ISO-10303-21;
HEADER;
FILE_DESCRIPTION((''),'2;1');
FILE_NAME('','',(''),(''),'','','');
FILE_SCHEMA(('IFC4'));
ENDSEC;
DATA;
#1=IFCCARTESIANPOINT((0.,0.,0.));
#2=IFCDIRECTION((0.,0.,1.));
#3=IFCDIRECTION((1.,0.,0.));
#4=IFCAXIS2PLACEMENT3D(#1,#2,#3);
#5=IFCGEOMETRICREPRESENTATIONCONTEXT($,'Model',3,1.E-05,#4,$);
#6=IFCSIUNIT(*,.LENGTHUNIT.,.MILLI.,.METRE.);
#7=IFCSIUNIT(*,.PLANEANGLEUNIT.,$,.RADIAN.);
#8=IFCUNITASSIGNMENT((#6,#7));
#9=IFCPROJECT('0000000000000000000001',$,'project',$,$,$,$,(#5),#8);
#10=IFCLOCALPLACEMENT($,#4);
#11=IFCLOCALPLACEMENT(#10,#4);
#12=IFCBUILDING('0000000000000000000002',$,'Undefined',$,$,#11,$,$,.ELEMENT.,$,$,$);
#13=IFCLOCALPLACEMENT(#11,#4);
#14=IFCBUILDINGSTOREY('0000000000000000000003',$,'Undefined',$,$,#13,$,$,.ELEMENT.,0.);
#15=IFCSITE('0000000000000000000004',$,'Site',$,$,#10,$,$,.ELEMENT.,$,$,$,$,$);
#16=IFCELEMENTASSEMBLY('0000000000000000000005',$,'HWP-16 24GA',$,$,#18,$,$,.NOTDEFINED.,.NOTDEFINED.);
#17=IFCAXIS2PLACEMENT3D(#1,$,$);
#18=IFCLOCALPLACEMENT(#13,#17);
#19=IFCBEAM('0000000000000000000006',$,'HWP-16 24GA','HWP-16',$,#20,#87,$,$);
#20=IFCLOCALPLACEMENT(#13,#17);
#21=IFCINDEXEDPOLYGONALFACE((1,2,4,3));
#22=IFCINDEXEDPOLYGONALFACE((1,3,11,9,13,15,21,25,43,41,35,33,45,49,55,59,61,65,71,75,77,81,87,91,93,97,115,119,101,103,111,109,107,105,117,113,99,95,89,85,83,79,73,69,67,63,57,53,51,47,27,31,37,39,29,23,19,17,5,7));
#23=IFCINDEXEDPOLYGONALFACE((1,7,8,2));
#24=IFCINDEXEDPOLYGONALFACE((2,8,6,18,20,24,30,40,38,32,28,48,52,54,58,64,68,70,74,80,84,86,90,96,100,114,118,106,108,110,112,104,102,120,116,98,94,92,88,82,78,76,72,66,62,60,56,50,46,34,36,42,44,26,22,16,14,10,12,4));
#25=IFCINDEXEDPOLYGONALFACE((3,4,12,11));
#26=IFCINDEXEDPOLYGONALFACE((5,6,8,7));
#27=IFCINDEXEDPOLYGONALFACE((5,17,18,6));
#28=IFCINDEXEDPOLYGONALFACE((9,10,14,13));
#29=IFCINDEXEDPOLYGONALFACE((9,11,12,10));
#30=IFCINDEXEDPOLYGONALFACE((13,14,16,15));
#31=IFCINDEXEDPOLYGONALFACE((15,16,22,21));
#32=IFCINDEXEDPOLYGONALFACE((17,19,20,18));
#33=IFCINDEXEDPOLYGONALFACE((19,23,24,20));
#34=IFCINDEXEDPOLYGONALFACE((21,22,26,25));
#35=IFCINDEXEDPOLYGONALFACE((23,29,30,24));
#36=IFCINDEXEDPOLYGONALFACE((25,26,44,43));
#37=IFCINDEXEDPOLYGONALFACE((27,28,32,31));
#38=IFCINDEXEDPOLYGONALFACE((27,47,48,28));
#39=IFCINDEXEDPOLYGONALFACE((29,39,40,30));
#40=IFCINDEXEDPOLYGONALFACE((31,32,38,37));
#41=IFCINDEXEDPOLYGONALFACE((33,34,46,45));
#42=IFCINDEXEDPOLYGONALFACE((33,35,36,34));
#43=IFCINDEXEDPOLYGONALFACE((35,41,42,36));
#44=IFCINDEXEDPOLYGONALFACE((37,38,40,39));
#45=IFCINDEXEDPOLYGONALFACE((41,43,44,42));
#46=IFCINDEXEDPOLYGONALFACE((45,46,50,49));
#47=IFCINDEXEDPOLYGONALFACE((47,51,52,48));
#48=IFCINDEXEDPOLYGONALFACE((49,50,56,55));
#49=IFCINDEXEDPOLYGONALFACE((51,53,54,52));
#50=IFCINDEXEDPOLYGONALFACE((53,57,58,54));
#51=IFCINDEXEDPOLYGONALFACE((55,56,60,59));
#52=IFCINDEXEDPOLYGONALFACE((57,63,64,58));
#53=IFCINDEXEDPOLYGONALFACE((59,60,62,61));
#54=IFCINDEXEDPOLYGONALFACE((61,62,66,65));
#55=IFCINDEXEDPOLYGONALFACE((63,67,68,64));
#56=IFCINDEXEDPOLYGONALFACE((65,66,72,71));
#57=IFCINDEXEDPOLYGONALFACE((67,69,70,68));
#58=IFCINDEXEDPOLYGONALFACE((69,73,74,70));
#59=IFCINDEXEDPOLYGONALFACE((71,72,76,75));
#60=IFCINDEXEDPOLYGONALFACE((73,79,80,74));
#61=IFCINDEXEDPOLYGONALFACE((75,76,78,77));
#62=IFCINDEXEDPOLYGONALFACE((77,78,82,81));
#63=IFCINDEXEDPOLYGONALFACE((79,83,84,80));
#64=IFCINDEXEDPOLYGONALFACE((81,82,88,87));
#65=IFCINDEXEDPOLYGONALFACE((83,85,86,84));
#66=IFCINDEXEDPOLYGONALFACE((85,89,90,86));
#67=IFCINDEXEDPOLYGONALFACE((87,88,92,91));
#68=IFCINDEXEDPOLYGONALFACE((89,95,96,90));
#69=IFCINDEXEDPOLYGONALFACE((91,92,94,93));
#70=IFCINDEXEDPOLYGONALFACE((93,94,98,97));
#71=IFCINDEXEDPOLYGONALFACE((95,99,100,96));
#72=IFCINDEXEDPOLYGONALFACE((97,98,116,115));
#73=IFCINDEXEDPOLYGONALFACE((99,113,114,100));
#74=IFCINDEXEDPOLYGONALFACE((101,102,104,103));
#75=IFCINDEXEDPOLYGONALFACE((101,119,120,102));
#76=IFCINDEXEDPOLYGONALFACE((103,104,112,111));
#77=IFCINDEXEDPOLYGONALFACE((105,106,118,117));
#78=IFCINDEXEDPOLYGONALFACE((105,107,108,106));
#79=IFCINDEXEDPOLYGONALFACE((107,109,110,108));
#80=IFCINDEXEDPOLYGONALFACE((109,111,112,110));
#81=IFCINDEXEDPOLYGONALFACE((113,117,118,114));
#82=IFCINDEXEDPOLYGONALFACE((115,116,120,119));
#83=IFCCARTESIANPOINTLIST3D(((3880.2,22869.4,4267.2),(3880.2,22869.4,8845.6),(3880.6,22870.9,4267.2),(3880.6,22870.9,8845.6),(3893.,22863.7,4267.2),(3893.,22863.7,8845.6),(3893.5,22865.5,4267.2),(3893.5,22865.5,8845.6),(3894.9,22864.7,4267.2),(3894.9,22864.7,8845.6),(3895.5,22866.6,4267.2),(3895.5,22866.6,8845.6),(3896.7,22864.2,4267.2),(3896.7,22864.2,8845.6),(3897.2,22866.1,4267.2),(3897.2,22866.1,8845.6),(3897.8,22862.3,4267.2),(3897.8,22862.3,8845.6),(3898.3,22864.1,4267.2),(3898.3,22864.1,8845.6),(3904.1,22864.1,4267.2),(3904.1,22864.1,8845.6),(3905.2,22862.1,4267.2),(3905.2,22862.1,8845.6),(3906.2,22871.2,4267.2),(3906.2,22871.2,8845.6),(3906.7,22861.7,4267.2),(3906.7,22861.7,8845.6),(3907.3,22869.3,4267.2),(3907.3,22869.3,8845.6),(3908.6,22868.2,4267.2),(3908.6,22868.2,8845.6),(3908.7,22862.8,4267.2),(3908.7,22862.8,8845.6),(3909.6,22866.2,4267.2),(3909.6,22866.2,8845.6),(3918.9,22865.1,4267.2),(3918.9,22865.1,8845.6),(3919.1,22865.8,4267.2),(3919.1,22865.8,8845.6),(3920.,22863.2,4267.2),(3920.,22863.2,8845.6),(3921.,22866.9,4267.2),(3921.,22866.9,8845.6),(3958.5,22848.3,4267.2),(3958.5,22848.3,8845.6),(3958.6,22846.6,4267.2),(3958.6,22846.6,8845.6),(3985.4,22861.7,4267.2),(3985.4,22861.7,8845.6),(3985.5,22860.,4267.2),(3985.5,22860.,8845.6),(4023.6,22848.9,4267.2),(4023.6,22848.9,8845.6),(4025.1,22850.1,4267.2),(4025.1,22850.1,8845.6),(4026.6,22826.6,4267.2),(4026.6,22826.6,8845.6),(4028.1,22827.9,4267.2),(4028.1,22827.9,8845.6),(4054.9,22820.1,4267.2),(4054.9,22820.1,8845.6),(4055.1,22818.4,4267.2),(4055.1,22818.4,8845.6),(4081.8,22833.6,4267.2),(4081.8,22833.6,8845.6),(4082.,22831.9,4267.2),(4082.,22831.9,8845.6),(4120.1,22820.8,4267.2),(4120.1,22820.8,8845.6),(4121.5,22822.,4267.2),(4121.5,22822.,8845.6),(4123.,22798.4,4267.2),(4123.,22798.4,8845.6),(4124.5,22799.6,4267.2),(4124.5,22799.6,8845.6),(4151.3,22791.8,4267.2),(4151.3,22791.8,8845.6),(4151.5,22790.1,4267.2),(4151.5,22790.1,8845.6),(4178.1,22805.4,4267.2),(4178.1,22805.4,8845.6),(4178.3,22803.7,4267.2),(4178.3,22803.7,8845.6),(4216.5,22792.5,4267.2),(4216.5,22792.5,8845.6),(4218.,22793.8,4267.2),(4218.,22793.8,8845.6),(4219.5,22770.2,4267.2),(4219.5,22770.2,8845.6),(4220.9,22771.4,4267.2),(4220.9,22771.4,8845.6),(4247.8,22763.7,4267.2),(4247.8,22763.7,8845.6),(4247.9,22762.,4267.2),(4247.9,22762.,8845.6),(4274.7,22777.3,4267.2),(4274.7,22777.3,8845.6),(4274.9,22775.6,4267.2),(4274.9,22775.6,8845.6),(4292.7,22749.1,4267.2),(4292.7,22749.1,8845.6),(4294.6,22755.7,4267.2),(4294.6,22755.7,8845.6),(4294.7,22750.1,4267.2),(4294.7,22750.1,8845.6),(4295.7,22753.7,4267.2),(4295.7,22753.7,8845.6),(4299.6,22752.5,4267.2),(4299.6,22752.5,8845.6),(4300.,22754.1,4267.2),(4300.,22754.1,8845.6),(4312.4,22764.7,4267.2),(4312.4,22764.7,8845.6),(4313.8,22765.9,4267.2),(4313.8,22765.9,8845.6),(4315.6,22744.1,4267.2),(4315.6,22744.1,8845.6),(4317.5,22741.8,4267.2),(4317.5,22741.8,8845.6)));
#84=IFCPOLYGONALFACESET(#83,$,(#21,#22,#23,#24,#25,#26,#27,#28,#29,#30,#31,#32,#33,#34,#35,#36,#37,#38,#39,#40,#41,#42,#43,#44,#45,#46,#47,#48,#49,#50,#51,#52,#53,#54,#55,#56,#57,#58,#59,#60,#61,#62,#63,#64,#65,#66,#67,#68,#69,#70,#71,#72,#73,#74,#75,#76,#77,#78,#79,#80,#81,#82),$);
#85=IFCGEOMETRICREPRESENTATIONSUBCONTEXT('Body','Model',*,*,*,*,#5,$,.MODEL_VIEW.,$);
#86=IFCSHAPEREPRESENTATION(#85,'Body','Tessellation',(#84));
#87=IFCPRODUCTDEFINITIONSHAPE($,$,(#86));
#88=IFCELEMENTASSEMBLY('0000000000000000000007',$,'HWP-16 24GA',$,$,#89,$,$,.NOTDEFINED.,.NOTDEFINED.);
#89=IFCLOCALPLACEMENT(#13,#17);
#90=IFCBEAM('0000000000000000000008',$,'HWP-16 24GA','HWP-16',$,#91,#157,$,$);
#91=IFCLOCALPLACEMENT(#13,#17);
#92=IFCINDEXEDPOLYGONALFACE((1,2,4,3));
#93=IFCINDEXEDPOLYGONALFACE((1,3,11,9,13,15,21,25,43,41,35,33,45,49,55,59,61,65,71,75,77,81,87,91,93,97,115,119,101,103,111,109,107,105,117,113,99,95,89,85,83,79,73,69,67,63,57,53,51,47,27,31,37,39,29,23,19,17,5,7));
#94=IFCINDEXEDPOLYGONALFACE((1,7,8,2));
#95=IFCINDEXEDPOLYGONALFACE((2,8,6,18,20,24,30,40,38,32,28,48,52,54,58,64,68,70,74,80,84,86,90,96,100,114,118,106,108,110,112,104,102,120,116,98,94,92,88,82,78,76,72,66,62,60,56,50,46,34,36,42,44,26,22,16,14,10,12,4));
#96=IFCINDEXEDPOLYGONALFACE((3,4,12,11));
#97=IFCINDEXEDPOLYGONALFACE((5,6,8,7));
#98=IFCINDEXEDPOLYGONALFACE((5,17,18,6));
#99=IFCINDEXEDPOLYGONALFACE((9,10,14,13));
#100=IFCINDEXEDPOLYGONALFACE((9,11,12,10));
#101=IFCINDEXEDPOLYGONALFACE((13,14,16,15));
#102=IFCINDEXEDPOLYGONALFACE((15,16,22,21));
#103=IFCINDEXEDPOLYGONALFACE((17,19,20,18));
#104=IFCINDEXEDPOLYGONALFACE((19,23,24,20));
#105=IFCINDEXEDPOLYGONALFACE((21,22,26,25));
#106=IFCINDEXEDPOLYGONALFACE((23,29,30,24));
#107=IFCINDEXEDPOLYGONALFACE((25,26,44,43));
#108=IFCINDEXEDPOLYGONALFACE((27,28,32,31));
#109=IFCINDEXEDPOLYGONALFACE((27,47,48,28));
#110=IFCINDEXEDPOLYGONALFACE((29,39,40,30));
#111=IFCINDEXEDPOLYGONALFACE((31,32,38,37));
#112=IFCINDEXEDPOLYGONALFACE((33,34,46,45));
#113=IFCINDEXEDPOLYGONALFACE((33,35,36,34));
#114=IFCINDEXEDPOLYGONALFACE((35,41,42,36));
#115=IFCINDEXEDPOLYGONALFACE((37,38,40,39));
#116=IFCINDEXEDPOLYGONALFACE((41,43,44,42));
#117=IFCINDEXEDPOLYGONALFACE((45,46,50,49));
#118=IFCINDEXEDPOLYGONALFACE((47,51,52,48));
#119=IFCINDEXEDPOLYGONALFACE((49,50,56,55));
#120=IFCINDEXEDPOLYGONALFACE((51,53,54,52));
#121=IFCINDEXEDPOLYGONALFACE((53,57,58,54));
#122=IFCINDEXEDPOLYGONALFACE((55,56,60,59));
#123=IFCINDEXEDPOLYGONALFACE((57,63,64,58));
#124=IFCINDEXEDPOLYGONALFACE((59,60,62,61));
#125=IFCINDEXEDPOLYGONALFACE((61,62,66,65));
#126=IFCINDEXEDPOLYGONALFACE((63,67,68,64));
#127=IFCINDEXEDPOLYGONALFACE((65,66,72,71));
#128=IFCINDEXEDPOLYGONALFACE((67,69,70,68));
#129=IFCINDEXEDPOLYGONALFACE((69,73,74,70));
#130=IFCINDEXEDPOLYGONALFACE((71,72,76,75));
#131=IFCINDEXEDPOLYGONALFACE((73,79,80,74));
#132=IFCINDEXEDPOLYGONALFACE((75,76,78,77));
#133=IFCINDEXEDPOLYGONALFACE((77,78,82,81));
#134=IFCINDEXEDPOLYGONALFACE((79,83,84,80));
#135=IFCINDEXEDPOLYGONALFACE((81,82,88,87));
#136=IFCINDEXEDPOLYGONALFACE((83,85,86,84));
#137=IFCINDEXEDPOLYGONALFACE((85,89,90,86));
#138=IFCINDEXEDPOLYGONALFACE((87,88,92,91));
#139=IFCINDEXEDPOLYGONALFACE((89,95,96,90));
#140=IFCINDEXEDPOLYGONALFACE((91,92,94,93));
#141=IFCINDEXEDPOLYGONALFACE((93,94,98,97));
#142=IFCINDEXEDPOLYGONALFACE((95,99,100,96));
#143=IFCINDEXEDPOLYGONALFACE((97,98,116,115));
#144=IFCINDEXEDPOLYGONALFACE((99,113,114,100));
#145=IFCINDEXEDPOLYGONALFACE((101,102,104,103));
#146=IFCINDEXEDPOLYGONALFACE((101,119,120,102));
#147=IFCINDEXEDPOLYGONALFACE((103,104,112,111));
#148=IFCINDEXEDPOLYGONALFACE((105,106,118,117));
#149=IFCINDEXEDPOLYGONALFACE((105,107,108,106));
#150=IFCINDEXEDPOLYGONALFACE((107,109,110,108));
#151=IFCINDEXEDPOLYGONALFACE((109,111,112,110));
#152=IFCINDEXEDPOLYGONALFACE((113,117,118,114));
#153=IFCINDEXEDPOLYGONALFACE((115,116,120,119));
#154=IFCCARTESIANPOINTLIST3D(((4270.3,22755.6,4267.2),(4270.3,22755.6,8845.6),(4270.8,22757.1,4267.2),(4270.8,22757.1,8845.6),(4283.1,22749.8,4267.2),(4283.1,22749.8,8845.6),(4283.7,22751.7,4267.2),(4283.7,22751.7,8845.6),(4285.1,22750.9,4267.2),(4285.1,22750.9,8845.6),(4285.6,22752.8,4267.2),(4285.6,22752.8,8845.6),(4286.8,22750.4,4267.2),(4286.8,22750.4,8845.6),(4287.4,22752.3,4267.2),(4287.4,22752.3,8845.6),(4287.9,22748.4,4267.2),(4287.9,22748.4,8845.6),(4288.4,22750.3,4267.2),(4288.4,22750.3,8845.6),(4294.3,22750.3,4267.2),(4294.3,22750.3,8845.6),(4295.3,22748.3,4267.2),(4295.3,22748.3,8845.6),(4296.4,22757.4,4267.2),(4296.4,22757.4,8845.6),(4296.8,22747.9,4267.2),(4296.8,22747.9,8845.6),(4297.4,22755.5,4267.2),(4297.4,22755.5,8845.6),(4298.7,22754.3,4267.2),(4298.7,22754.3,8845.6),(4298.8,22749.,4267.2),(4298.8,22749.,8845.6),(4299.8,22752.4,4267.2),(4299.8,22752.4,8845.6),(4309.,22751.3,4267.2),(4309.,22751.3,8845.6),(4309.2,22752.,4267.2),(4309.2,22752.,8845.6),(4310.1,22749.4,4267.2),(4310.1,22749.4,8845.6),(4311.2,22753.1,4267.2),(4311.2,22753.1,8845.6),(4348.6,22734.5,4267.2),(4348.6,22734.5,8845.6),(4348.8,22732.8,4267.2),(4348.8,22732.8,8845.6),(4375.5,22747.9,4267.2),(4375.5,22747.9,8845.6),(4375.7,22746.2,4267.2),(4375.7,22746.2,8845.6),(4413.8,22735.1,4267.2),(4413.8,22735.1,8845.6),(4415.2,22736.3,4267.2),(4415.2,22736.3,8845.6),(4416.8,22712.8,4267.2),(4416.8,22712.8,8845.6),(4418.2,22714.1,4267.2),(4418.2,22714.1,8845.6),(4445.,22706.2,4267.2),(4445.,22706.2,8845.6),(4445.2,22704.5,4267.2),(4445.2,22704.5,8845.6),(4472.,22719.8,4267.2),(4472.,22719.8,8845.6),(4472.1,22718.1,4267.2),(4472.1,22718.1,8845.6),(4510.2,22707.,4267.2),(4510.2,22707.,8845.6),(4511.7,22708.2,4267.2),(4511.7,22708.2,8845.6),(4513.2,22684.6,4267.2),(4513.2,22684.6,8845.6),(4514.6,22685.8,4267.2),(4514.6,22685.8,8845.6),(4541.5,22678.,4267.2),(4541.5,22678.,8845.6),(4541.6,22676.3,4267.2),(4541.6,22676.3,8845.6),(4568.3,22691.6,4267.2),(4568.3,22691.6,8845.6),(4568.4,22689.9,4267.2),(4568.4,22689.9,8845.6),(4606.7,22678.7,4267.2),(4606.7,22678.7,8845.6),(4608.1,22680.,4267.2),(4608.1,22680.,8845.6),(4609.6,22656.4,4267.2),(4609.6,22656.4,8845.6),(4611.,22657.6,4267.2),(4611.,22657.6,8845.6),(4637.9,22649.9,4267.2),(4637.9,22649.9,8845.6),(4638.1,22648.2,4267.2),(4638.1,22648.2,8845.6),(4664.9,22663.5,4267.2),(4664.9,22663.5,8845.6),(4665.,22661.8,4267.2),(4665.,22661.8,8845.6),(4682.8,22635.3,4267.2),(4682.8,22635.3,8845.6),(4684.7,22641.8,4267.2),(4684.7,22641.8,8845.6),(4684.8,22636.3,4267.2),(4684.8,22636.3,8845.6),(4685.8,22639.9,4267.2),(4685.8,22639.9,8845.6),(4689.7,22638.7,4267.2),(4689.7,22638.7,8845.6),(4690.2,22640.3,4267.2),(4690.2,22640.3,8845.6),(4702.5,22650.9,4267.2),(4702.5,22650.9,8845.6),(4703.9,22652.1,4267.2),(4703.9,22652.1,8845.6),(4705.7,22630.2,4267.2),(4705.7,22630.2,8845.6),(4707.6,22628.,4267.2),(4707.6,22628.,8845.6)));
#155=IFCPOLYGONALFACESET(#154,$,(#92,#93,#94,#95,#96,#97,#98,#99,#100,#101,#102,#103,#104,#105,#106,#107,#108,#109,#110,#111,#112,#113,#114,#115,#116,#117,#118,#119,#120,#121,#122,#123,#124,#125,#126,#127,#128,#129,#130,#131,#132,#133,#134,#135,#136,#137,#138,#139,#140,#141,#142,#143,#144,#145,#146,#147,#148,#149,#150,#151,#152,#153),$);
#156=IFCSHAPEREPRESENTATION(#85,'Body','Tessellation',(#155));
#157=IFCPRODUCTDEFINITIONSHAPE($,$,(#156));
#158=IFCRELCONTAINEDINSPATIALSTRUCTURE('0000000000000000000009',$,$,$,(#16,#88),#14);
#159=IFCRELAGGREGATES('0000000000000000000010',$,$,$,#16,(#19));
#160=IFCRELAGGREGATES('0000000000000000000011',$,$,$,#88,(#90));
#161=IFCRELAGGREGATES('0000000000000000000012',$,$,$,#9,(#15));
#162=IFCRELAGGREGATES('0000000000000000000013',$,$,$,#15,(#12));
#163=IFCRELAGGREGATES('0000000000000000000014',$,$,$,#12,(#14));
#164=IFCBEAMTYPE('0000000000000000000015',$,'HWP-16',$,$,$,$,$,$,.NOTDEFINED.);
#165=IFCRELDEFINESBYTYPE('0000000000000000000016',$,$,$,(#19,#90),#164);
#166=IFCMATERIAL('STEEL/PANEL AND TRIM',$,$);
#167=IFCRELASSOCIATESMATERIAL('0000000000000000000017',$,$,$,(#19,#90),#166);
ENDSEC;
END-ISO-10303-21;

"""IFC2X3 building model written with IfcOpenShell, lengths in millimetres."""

from ifc_helpers import new_model, si_unit, frame, origin_with_axes, place, context, subcontext, project, spatial, polyline, outline, extrude, clip, halfspace, material, type_object, element, aggregate, save


model = new_model("IFC2X3")

# Units and contexts
model_context = context("Model", 3, precision=1e-05, world=origin_with_axes())
body_context = subcontext(model_context, "Body", "Model", "MODEL_VIEW")
ifc_project = project(units=[si_unit("LENGTHUNIT", "METRE", prefix="MILLI"), si_unit("PLANEANGLEUNIT", "RADIAN")], contexts=[model_context])

# Site, building, storey
site_placement = place(None, origin_with_axes())
site = spatial("IfcSite", under=ifc_project, at=site_placement, Name="Site", CompositionType="ELEMENT")
building_placement = place(site_placement, origin_with_axes())
building = spatial("IfcBuilding", under=site, at=building_placement, Name="Undefined", CompositionType="ELEMENT")
storey_placement = place(building_placement, origin_with_axes())
storey = spatial("IfcBuildingStorey", under=building, at=storey_placement, Name="Undefined", CompositionType="ELEMENT", Elevation=0.0)

# Element assemblies, beams
ifc_material_1 = material(Name="STEEL/PANEL AND TRIM")
beam_type_1 = type_object("IfcBeamType", Name="HWP-16", PredefinedType="NOTDEFINED")
assembly_1_placement = place(storey_placement, origin_with_axes())
assembly_1 = element("IfcElementAssembly", 1, at=assembly_1_placement, inside=storey, Name="HWP-16 24GA", AssemblyPlace="NOTDEFINED", PredefinedType="NOTDEFINED")
beam_1_placement = place(assembly_1_placement, frame((4313.8, 22765.9, 8845.6), z_axis=(-0.280057, -0.959983, 0.0), x_axis=(0.0, 0.0, -1.0)))
beam_1 = element("IfcBeam", 2, at=beam_1_placement, type_object=beam_type_1, material=ifc_material_1, Name="HWP-16 24GA", Description="HWP-16", context=body_context, shape_type="Clipping", body=[
    clip(extrude(outline(polyline([(40.7, 0.0), (0.0, 0.0), (-10.3, 22.1), (15.5, 22.1), (15.5, 15.2), (9.9, 15.2), (9.9, 16.8), (13.9, 16.8), (13.9, 20.5), (-7.8, 20.5), (1.0, 1.6), (40.1, 1.6), (62.1, 22.2), (91.7, 22.3), (100.8, 1.7), (140.6, 1.7), (162.6, 22.2), (192.2, 22.2), (201.3, 1.6), (241.0, 1.6), (263.1, 22.1), (292.7, 22.1), (301.8, 1.6), (341.5, 1.6), (363.5, 22.0), (417.6, 22.0), (417.6, 15.3), (406.9, 15.3), (406.9, 14.6), (419.2, 14.6), (419.2, 22.1), (426.4, 22.1), (426.4, 24.0), (431.3, 24.0), (431.3, 22.1), (445.2, 22.1), (445.2, 20.5), (429.7, 20.5), (429.7, 22.5), (427.9, 22.5), (427.9, 20.5), (420.7, 20.5), (420.7, 13.0), (405.3, 13.0), (405.3, 16.9), (416.0, 16.9), (416.0, 20.4), (364.1, 20.4), (342.1, 0.0), (300.7, 0.0), (291.6, 20.5), (263.7, 20.5), (241.6, 0.0), (200.3, 0.0), (191.2, 20.6), (163.2, 20.6), (141.3, 0.1), (99.8, 0.1), (90.7, 20.7), (62.7, 20.6), (40.7, 0.0)])), frame((10000.0, 0.0, 0.0), z_axis=(-1.0, 0.0, 0.0), x_axis=(0.0, -1.0, 0.0)), (0.0, 0.0, 1.0), 10000.0), halfspace(frame((4578.4, -500.0, -500.0), z_axis=(1.0, 0.0, 0.0), x_axis=(0.0, 0.0, 1.0)), False)),
])
aggregate(assembly_1, [beam_1])
assembly_2_placement = place(storey_placement, origin_with_axes())
assembly_2 = element("IfcElementAssembly", 3, at=assembly_2_placement, inside=storey, Name="HWP-16 24GA", AssemblyPlace="NOTDEFINED", PredefinedType="NOTDEFINED")
beam_2_placement = place(assembly_2_placement, frame((4703.9, 22652.1, 8845.6), z_axis=(-0.280057, -0.959983, 0.0), x_axis=(0.0, 0.0, -1.0)))
beam_2 = element("IfcBeam", 4, at=beam_2_placement, type_object=beam_type_1, material=ifc_material_1, Name="HWP-16 24GA", Description="HWP-16", context=body_context, shape_type="Clipping", body=[
    clip(extrude(outline(polyline([(40.7, 0.0), (0.0, 0.0), (-10.3, 22.1), (15.5, 22.1), (15.5, 15.2), (9.9, 15.2), (9.9, 16.8), (13.9, 16.8), (13.9, 20.5), (-7.8, 20.5), (1.0, 1.6), (40.1, 1.6), (62.1, 22.2), (91.7, 22.3), (100.8, 1.7), (140.6, 1.7), (162.6, 22.2), (192.2, 22.2), (201.3, 1.6), (241.0, 1.6), (263.1, 22.1), (292.7, 22.1), (301.8, 1.6), (341.5, 1.6), (363.5, 22.0), (417.6, 22.0), (417.6, 15.3), (406.9, 15.3), (406.9, 14.6), (419.2, 14.6), (419.2, 22.1), (426.4, 22.1), (426.4, 24.0), (431.3, 24.0), (431.3, 22.1), (445.2, 22.1), (445.2, 20.5), (429.7, 20.5), (429.7, 22.5), (427.9, 22.5), (427.9, 20.5), (420.7, 20.5), (420.7, 13.0), (405.3, 13.0), (405.3, 16.9), (416.0, 16.9), (416.0, 20.4), (364.1, 20.4), (342.1, 0.0), (300.7, 0.0), (291.6, 20.5), (263.7, 20.5), (241.6, 0.0), (200.3, 0.0), (191.2, 20.6), (163.2, 20.6), (141.3, 0.1), (99.8, 0.1), (90.7, 20.7), (62.7, 20.6), (40.7, 0.0)])), frame((10000.0, 0.0, 0.0), z_axis=(-1.0, 0.0, 0.0), x_axis=(0.0, -1.0, 0.0)), (0.0, 0.0, 1.0), 10000.0), halfspace(frame((4578.4, -500.0, -500.0), z_axis=(1.0, 0.0, 0.0), x_axis=(0.0, 0.0, 1.0)), False)),
])
aggregate(assembly_2, [beam_2])

save(model, "model.ifc")
